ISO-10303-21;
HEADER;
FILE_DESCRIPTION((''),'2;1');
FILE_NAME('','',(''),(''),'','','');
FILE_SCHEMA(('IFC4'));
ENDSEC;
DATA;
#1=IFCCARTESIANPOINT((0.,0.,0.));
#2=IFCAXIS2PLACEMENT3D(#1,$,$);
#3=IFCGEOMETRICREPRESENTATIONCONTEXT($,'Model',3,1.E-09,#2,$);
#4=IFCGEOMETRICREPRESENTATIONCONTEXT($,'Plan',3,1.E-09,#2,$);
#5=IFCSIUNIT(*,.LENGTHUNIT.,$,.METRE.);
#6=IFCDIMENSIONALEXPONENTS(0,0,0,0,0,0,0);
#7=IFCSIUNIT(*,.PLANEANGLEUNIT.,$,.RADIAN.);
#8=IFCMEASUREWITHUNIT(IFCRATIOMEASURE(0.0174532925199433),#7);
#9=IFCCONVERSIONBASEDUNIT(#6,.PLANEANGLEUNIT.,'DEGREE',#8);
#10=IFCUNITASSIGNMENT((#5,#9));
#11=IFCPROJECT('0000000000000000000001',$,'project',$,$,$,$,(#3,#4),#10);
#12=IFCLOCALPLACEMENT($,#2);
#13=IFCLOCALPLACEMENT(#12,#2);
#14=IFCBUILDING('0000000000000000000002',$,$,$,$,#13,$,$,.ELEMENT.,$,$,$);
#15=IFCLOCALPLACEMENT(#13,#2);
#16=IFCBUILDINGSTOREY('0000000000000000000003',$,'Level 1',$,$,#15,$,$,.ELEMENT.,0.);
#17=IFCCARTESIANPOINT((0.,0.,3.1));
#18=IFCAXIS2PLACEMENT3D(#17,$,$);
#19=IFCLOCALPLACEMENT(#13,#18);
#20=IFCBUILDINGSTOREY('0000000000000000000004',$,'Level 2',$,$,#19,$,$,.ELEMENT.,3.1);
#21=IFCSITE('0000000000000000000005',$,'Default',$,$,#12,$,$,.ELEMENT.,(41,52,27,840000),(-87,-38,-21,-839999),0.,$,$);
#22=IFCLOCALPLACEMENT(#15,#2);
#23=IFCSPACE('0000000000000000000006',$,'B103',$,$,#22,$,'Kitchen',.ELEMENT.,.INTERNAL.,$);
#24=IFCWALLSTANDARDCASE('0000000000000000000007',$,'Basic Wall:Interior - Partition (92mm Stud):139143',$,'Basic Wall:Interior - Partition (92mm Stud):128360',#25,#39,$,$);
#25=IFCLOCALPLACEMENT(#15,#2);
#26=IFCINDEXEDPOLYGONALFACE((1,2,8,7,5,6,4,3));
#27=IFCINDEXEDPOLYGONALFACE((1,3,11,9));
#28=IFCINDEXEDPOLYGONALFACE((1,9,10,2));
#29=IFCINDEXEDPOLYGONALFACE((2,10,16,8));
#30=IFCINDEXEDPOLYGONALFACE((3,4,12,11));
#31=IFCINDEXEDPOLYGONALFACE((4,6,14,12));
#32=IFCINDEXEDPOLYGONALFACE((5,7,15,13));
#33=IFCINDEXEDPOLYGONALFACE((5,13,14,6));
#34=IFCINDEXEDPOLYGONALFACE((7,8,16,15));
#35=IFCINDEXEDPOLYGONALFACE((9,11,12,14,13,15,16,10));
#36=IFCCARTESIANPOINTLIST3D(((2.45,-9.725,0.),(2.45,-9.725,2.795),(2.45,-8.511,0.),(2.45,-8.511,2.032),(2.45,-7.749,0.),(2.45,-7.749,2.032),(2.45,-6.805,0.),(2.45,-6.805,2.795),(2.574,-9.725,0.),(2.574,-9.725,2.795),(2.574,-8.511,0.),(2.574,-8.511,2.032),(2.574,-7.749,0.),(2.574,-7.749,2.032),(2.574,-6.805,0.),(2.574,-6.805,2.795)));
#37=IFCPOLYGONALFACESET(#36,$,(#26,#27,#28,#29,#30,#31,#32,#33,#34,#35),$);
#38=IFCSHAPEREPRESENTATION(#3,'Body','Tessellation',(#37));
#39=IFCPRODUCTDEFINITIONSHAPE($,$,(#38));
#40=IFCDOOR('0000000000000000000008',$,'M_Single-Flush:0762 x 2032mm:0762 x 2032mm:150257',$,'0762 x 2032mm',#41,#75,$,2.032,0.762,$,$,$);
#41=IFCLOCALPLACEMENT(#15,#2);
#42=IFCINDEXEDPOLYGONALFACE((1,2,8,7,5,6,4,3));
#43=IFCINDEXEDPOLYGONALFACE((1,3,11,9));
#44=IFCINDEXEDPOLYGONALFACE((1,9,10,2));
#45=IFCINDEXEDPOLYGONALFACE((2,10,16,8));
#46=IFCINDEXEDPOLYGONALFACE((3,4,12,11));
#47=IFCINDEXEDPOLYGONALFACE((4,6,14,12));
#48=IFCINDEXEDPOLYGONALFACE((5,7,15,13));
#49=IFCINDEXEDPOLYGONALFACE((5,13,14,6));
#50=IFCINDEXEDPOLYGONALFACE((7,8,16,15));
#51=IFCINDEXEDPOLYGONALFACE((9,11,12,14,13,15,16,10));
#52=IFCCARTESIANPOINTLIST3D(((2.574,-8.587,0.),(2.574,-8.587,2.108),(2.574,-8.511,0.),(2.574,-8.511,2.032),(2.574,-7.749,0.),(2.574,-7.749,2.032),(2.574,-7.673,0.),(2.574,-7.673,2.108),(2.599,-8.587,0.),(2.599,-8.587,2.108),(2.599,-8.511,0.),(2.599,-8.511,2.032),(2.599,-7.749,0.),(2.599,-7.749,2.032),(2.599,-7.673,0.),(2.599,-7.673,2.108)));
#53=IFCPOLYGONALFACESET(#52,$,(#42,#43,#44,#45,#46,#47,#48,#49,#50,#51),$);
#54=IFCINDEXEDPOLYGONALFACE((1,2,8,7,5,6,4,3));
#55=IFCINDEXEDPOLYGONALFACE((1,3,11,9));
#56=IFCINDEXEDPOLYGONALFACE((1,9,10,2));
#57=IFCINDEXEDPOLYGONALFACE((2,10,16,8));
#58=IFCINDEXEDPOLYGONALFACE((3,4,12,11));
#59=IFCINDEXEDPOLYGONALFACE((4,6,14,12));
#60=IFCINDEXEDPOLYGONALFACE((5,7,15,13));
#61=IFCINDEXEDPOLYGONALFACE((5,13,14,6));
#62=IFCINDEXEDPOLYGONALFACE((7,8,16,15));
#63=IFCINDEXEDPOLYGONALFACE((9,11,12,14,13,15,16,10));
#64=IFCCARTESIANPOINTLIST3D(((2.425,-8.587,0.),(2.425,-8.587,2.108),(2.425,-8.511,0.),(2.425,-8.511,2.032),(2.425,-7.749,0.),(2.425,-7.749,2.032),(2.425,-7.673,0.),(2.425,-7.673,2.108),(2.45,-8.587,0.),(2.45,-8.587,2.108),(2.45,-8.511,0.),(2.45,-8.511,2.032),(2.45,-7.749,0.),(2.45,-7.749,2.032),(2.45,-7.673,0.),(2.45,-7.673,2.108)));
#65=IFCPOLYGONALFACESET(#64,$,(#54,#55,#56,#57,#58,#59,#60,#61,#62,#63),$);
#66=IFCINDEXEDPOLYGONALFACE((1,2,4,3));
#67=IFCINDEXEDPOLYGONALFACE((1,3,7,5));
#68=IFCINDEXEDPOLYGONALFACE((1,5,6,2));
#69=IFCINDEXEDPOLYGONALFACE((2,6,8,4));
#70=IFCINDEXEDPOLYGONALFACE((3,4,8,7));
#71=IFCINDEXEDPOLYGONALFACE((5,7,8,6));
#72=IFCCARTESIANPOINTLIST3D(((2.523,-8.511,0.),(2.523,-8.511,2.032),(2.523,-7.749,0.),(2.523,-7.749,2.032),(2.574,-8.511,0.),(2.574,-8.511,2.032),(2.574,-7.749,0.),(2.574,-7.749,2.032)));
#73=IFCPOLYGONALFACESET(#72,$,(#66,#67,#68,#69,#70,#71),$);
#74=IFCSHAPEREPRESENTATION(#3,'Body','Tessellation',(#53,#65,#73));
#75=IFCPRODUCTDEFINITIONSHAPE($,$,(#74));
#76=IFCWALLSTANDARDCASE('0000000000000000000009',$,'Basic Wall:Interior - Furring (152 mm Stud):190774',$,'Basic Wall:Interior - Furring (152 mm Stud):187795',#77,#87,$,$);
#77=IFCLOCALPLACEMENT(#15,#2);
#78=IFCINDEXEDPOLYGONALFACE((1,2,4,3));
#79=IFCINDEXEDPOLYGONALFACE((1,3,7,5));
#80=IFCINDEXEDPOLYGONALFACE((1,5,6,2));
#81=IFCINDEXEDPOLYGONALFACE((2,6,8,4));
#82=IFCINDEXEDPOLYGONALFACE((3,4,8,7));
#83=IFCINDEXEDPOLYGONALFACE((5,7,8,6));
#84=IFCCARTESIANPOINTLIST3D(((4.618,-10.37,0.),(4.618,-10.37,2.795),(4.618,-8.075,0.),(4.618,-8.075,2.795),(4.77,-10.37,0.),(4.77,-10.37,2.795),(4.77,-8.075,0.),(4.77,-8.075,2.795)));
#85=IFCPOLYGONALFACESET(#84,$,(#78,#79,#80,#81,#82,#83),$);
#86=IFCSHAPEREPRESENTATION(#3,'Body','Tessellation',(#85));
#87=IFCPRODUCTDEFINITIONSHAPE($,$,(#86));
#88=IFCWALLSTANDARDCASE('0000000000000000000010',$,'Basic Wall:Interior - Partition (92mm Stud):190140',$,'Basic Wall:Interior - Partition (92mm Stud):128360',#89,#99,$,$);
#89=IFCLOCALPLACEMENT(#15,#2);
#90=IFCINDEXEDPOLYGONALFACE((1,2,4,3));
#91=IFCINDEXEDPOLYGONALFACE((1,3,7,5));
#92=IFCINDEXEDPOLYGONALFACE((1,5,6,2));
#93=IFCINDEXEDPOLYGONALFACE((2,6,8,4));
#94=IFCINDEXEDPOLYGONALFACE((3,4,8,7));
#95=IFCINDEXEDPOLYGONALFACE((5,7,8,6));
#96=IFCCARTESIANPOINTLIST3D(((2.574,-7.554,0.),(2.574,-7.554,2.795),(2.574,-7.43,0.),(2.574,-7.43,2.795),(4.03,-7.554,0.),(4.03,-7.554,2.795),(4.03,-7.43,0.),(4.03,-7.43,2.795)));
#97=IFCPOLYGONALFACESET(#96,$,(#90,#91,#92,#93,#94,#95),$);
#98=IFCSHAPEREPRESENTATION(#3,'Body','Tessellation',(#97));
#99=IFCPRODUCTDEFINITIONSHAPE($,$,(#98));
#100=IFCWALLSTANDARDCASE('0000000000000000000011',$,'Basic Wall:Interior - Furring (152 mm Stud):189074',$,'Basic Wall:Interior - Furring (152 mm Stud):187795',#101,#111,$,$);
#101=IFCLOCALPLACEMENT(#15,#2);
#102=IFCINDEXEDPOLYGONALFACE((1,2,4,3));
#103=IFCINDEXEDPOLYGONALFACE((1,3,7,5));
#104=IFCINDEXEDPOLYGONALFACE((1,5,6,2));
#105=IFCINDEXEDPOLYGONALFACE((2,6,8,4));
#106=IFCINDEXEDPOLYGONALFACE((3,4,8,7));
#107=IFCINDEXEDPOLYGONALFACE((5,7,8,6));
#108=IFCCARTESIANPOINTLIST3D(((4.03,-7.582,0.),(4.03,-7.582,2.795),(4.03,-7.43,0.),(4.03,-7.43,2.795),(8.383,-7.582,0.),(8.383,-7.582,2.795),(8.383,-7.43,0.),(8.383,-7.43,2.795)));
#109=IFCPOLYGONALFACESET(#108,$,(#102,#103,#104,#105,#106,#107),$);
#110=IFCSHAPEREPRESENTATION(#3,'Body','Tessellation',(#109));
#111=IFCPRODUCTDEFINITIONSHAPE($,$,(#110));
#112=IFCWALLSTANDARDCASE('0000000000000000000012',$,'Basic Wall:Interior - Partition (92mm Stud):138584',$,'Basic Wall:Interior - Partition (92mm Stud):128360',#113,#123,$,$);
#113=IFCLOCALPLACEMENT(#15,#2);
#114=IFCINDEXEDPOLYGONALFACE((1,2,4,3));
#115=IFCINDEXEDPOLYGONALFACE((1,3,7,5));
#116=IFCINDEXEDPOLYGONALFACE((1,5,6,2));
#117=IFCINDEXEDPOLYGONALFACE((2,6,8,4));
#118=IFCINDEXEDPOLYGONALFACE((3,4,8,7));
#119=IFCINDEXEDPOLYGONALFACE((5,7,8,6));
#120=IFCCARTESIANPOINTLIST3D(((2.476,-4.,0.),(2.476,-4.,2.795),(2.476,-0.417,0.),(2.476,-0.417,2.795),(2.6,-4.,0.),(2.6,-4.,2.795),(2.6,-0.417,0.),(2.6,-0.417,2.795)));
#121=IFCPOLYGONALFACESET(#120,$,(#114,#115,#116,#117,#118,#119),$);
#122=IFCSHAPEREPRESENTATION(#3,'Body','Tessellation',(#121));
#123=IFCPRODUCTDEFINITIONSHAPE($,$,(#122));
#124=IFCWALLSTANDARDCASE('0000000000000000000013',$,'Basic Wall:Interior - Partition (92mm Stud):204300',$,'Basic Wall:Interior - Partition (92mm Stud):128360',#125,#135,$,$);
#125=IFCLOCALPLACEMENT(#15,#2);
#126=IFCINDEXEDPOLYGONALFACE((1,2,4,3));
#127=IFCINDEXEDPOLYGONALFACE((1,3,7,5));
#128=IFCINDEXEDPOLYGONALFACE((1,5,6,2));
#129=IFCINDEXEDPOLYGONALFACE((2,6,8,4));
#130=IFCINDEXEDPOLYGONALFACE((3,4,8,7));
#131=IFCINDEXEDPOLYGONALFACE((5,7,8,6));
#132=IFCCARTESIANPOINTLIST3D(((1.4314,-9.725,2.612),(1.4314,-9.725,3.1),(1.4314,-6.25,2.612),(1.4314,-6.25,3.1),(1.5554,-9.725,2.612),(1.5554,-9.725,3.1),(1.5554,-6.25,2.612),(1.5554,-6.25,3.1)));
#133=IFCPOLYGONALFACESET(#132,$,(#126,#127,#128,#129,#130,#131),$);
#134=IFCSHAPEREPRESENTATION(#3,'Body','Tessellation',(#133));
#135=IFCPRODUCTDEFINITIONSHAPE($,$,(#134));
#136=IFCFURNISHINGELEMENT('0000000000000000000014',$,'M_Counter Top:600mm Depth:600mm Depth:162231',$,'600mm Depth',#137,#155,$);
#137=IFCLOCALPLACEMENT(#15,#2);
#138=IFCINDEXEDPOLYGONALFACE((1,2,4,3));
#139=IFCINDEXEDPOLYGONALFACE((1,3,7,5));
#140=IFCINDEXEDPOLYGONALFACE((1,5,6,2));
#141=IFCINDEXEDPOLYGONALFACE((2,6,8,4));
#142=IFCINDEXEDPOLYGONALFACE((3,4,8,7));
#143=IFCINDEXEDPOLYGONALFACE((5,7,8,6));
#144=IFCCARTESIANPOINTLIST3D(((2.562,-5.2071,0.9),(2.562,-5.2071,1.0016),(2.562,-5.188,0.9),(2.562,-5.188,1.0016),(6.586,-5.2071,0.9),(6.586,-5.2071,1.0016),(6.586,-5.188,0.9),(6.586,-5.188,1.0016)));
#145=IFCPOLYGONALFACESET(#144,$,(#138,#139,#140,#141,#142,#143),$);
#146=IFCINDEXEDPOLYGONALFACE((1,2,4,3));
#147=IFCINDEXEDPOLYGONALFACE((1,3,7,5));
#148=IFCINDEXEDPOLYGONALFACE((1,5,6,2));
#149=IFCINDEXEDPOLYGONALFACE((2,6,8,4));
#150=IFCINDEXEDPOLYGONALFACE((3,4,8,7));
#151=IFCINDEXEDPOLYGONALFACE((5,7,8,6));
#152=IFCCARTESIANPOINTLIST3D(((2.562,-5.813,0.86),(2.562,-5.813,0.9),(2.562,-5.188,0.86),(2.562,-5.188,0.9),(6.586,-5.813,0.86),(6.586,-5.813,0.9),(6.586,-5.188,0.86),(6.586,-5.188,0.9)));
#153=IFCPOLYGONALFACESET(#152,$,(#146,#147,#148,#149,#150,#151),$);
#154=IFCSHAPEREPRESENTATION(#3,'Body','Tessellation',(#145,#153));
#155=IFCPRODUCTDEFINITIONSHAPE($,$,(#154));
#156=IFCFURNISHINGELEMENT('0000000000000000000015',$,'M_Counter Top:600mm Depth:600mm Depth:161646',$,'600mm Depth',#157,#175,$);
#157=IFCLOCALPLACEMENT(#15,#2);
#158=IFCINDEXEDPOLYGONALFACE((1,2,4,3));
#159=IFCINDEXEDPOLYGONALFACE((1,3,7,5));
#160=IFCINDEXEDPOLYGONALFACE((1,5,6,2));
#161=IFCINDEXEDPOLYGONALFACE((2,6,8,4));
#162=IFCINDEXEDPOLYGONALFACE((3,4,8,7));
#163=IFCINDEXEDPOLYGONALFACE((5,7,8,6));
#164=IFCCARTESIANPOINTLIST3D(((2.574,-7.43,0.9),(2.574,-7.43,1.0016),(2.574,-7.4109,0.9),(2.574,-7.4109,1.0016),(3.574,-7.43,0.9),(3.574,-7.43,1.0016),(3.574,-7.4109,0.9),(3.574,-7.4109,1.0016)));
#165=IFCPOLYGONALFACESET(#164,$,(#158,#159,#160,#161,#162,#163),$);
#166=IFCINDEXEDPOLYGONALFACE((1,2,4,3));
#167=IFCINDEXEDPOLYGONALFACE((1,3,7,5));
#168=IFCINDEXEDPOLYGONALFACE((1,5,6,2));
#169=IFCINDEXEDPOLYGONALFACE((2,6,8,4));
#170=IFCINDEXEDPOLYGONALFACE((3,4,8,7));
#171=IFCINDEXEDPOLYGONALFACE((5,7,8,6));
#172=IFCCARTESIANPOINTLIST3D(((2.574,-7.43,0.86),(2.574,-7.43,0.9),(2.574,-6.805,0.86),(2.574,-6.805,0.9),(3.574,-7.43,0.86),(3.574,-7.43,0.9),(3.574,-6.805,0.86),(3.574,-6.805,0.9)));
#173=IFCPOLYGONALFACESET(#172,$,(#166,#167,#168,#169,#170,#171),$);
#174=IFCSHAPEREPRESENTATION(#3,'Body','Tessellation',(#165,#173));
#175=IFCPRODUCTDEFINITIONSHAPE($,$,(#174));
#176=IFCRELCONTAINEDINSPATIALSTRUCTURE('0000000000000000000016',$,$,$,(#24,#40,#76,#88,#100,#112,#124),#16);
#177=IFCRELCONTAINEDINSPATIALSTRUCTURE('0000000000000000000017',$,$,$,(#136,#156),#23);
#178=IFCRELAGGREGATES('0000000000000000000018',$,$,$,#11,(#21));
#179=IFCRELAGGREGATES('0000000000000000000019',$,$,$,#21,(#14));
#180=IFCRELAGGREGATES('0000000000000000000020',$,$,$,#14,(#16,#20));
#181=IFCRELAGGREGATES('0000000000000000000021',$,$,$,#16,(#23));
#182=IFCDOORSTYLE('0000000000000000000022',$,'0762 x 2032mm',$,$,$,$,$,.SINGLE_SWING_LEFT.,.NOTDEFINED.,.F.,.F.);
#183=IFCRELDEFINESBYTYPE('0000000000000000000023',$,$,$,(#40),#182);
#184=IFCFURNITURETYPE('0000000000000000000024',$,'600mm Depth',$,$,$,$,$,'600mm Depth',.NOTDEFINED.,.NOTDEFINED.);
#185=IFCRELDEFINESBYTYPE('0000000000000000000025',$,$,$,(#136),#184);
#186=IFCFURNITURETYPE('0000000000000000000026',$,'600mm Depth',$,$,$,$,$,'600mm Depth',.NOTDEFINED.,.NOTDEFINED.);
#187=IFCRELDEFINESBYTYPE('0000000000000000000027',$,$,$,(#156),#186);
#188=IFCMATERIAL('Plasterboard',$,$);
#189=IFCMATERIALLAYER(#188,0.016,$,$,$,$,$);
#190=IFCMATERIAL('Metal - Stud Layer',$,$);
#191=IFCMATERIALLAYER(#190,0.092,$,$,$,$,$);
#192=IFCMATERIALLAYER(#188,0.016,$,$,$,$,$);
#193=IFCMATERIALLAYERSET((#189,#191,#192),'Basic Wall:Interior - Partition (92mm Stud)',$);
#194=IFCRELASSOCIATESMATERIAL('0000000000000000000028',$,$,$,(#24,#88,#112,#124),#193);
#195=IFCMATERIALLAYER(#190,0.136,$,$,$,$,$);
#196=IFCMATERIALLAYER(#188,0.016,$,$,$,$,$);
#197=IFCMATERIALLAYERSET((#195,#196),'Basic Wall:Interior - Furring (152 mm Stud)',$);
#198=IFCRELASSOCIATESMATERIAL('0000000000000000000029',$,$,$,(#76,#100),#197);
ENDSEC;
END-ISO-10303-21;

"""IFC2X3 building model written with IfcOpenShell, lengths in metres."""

from ifc_helpers import new_model, entity, si_unit, converted_unit, frame, frame_2d, origin, origin_2d_with_axis, place, context, project, spatial, polyline, rectangle, outline, extrude, clip, bounded_halfspace, source, transform, mapped, material, layer, layer_set, layer_usage, type_object, type_shapes, element, fill, save


model = new_model("IFC2X3")

# Units and contexts
model_context = context("Model", 3, precision=1e-09, world=origin())
plan_context = context("Plan", 3, precision=1e-09, world=origin())
ifc_project = project(units=[si_unit("LENGTHUNIT", "METRE"), converted_unit("PLANEANGLEUNIT", "DEGREE", entity("IfcRatioMeasure", 0.0174532925199433), si_unit("PLANEANGLEUNIT", "RADIAN"), dimensions=[0, 0, 0, 0, 0, 0, 0])], contexts=[model_context, plan_context])

# Site, building, storey
site_placement = place(None, origin())
site = spatial("IfcSite", under=ifc_project, at=site_placement, Name="Default", CompositionType="ELEMENT", RefLatitude=(41, 52, 27, 840000), RefLongitude=(-87, -38, -21, -839999), RefElevation=0.0)
building_placement = place(site_placement, origin())
building = spatial("IfcBuilding", under=site, at=building_placement, CompositionType="ELEMENT")
storey_1_placement = place(building_placement, origin())
storey_1 = spatial("IfcBuildingStorey", under=building, at=storey_1_placement, Name="Level 1", CompositionType="ELEMENT", Elevation=0.0)

# Shared definitions
ifc_material_1 = material(Name="Metal - Stud Layer")
ifc_material_2 = material(Name="Plasterboard")

# Shared definitions
ifc_layer_1 = layer(ifc_material_2, 0.016)
ifc_layer_2 = layer(ifc_material_1, 0.092)
ifc_layer_3 = layer(ifc_material_2, 0.016)
ifc_layer_set_1 = layer_set([ifc_layer_1, ifc_layer_2, ifc_layer_3], Name="Basic Wall:Interior - Partition (92mm Stud)")
ifc_layer_usage_1 = layer_usage(ifc_layer_set_1, "AXIS2", "NEGATIVE", 0.062)

# Shared definitions
storey_2_placement = place(building_placement, frame((0.0, 0.0, 3.1)))
storey_2 = spatial("IfcBuildingStorey", under=building, at=storey_2_placement, Name="Level 2", CompositionType="ELEMENT", Elevation=3.1)

# Wall, opening, door
wall_1_placement = place(storey_1_placement, frame((2.512, -6.805, 0.0), z_axis=(0.0, 0.0, 1.0), x_axis=(0.0, -1.0, 0.0)))
wall_1 = element("IfcWallStandardCase", 1, at=wall_1_placement, inside=storey_1, material=ifc_layer_usage_1, Name="Basic Wall:Interior - Partition (92mm Stud):139143", ObjectType="Basic Wall:Interior - Partition (92mm Stud):128360", context=model_context, shape_type="SweptSolid", body=[
    extrude(rectangle(XDim=2.92, YDim=0.124, at=frame_2d((1.46, 0.0), x_axis=(-1.0, 0.0))), origin(), (0.0, 0.0, 1.0), 2.795),
])
opening_1_placement = place(wall_1_placement, frame((0.944, -0.062, 0.0)))
opening_1 = element("IfcOpeningElement", 2, at=opening_1_placement, cuts=wall_1, ObjectType="Opening", context=model_context, shape_type="SweptSolid", body=[
    extrude(rectangle(XDim=0.762, YDim=2.032, at=frame_2d((1.016, 0.381), x_axis=(0.0, -1.0))), frame((0.0, 0.0, 0.0), z_axis=(0.0, 1.0, 0.0), x_axis=(0.0, 0.0, 1.0)), (0.0, 0.0, 1.0), 0.124),
])
door_style_1 = type_object("IfcDoorStyle", Name="0762 x 2032mm", ConstructionType="NOTDEFINED", OperationType="SINGLE_SWING_LEFT", ParameterTakesPrecedence=False, Sizeable=False)
shared_shape_1 = source(origin(), model_context, "Body", "SweptSolid", [
    extrude(outline(polyline([(-0.457, -1.073), (0.457, -1.073), (0.457, 1.035), (0.381, 1.035), (0.381, -0.997), (-0.381, -0.997), (-0.381, 1.035), (-0.457, 1.035), (-0.457, -1.073)])), frame((0.381, 0.149, 1.035), z_axis=(0.0, -1.0, 0.0), x_axis=(-1.0, 0.0, 0.0)), (0.0, 0.0, 1.0), 0.025),
    extrude(outline(polyline([(-1.073, -0.457), (1.035, -0.457), (1.035, -0.381), (-0.997, -0.381), (-0.997, 0.381), (1.035, 0.381), (1.035, 0.457), (-1.073, 0.457), (-1.073, -0.457)])), frame((0.381, 0.0, 1.035), z_axis=(0.0, -1.0, 0.0), x_axis=(0.0, 0.0, -1.0)), (0.0, 0.0, 1.0), 0.025),
    extrude(rectangle(XDim=0.762, YDim=0.051, at=origin_2d_with_axis()), frame((0.381, 0.0985, 0.0)), (0.0, 0.0, 1.0), 2.032),
])
type_shapes(door_style_1, [shared_shape_1])
door_1_placement = place(opening_1_placement, origin())
door_1 = element("IfcDoor", 3, at=door_1_placement, inside=storey_1, type_object=door_style_1, Name="M_Single-Flush:0762 x 2032mm:0762 x 2032mm:150257", ObjectType="0762 x 2032mm", OverallHeight=2.032, OverallWidth=0.762, context=model_context, shape_type="MappedRepresentation", body=[
    mapped(shared_shape_1, transform((0.0, 0.0, 0.0), scale=1.0)),
])
fill(opening_1, door_1)

# Walls
ifc_layer_4 = layer(ifc_material_1, 0.136)
ifc_layer_5 = layer(ifc_material_2, 0.016)
ifc_layer_set_2 = layer_set([ifc_layer_4, ifc_layer_5], Name="Basic Wall:Interior - Furring (152 mm Stud)")
ifc_layer_usage_2 = layer_usage(ifc_layer_set_2, "AXIS2", "POSITIVE", -0.076)
wall_2_placement = place(storey_1_placement, frame((4.694, -8.075, 0.0), z_axis=(0.0, 0.0, 1.0), x_axis=(0.0, -1.0, 0.0)))
element("IfcWallStandardCase", 4, at=wall_2_placement, inside=storey_1, material=ifc_layer_usage_2, Name="Basic Wall:Interior - Furring (152 mm Stud):190774", ObjectType="Basic Wall:Interior - Furring (152 mm Stud):187795", context=model_context, shape_type="SweptSolid", body=[
    extrude(rectangle(XDim=2.295, YDim=0.152, at=frame_2d((1.1475, 0.0), x_axis=(-1.0, 0.0))), origin(), (0.0, 0.0, 1.0), 2.795),
])
wall_3_placement = place(storey_1_placement, frame((4.03, -7.492, 0.0), z_axis=(0.0, 0.0, 1.0), x_axis=(-1.0, 0.0, 0.0)))
element("IfcWallStandardCase", 5, at=wall_3_placement, inside=storey_1, material=ifc_layer_usage_1, Name="Basic Wall:Interior - Partition (92mm Stud):190140", ObjectType="Basic Wall:Interior - Partition (92mm Stud):128360", context=model_context, shape_type="SweptSolid", body=[
    extrude(rectangle(XDim=1.456, YDim=0.124, at=frame_2d((0.728, 0.0), x_axis=(-1.0, 0.0))), origin(), (0.0, 0.0, 1.0), 2.795),
])
ifc_layer_usage_3 = layer_usage(ifc_layer_set_2, "AXIS2", "NEGATIVE", 0.076)
wall_4_placement = place(storey_1_placement, frame((8.383, -7.506, 0.0), z_axis=(0.0, 0.0, 1.0), x_axis=(-1.0, 0.0, 0.0)))
element("IfcWallStandardCase", 6, at=wall_4_placement, inside=storey_1, material=ifc_layer_usage_3, Name="Basic Wall:Interior - Furring (152 mm Stud):189074", ObjectType="Basic Wall:Interior - Furring (152 mm Stud):187795", context=model_context, shape_type="Clipping", body=[
    clip(extrude(rectangle(XDim=4.353, YDim=0.152, at=frame_2d((2.1765, 0.0), x_axis=(-1.0, 0.0))), origin(), (0.0, 0.0, 1.0), 2.795), bounded_halfspace(frame((0.0, -0.076, 2.795), z_axis=(0.0, 0.0, -1.0), x_axis=(0.0, 1.0, 0.0)), True, frame((0.0, -0.076, 2.795)), polyline([(0.0, 0.0), (3.708, 0.0), (3.708, 0.152), (0.0, 0.152), (0.0, 0.0)]))),
])
wall_5_placement = place(storey_1_placement, frame((2.538, -0.417, 0.0), z_axis=(0.0, 0.0, 1.0), x_axis=(0.0, -1.0, 0.0)))
element("IfcWallStandardCase", 7, at=wall_5_placement, inside=storey_1, material=ifc_layer_usage_1, Name="Basic Wall:Interior - Partition (92mm Stud):138584", ObjectType="Basic Wall:Interior - Partition (92mm Stud):128360", context=model_context, shape_type="SweptSolid", body=[
    extrude(rectangle(XDim=3.583, YDim=0.124, at=frame_2d((1.7915, 0.0), x_axis=(-1.0, 0.0))), origin(), (0.0, 0.0, 1.0), 2.795),
])
wall_6_placement = place(storey_1_placement, frame((1.4934, -6.25, 2.612), z_axis=(0.0, 0.0, 1.0), x_axis=(0.0, -1.0, 0.0)))
element("IfcWallStandardCase", 8, at=wall_6_placement, inside=storey_1, material=ifc_layer_usage_1, Name="Basic Wall:Interior - Partition (92mm Stud):204300", ObjectType="Basic Wall:Interior - Partition (92mm Stud):128360", context=model_context, shape_type="SweptSolid", body=[
    extrude(rectangle(XDim=3.475, YDim=0.124, at=frame_2d((1.7375, 0.0), x_axis=(-1.0, 0.0))), origin(), (0.0, 0.0, 1.0), 0.488),
])

# Shared definitions
space_1_placement = place(storey_1_placement, origin())
space_1 = spatial("IfcSpace", under=storey_1, at=space_1_placement, Name="B103", LongName="Kitchen", CompositionType="ELEMENT", InteriorOrExteriorSpace="INTERNAL")

# Furnishing elements
furniture_type_1 = type_object("IfcFurnitureType", Name="600mm Depth", ElementType="600mm Depth", AssemblyPlace="NOTDEFINED")
shared_shape_2 = source(origin(), model_context, "Body", "SweptSolid", [
    extrude(rectangle(XDim=0.0191, YDim=4.024, at=origin_2d_with_axis()), frame((0.8115, -0.0095, 0.9), z_axis=(0.0, 0.0, 1.0), x_axis=(0.0, -1.0, 0.0)), (0.0, 0.0, 1.0), 0.1016),
    extrude(rectangle(XDim=4.024, YDim=0.625, at=origin_2d_with_axis()), frame((0.8115, -0.3125, 0.86), z_axis=(0.0, 0.0, 1.0), x_axis=(-1.0, 0.0, 0.0)), (0.0, 0.0, 1.0), 0.04),
])
type_shapes(furniture_type_1, [shared_shape_2])
furnishing_1_placement = place(space_1_placement, frame((3.7625, -5.188, 0.0)))
element("IfcFurnishingElement", 9, at=furnishing_1_placement, inside=space_1, type_object=furniture_type_1, Name="M_Counter Top:600mm Depth:600mm Depth:162231", ObjectType="600mm Depth", context=model_context, shape_type="MappedRepresentation", body=[
    mapped(shared_shape_2, transform((0.0, 0.0, 0.0), scale=1.0)),
])
furniture_type_2 = type_object("IfcFurnitureType", Name="600mm Depth", ElementType="600mm Depth", AssemblyPlace="NOTDEFINED")
shared_shape_3 = source(origin(), model_context, "Body", "SweptSolid", [
    extrude(rectangle(XDim=0.0191, YDim=1.0, at=origin_2d_with_axis()), frame((-0.7005, -0.0095, 0.9), z_axis=(0.0, 0.0, 1.0), x_axis=(0.0, -1.0, 0.0)), (0.0, 0.0, 1.0), 0.1016),
    extrude(rectangle(XDim=1.0, YDim=0.625, at=origin_2d_with_axis()), frame((-0.7005, -0.3125, 0.86), z_axis=(0.0, 0.0, 1.0), x_axis=(-1.0, 0.0, 0.0)), (0.0, 0.0, 1.0), 0.04),
])
type_shapes(furniture_type_2, [shared_shape_3])
furnishing_2_placement = place(space_1_placement, frame((2.3735, -7.43, 0.0), z_axis=(0.0, 0.0, 1.0), x_axis=(-1.0, 0.0, 0.0)))
element("IfcFurnishingElement", 10, at=furnishing_2_placement, inside=space_1, type_object=furniture_type_2, Name="M_Counter Top:600mm Depth:600mm Depth:161646", ObjectType="600mm Depth", context=model_context, shape_type="MappedRepresentation", body=[
    mapped(shared_shape_3, transform((0.0, 0.0, 0.0), scale=1.0)),
])

save(model, "model.ifc")
